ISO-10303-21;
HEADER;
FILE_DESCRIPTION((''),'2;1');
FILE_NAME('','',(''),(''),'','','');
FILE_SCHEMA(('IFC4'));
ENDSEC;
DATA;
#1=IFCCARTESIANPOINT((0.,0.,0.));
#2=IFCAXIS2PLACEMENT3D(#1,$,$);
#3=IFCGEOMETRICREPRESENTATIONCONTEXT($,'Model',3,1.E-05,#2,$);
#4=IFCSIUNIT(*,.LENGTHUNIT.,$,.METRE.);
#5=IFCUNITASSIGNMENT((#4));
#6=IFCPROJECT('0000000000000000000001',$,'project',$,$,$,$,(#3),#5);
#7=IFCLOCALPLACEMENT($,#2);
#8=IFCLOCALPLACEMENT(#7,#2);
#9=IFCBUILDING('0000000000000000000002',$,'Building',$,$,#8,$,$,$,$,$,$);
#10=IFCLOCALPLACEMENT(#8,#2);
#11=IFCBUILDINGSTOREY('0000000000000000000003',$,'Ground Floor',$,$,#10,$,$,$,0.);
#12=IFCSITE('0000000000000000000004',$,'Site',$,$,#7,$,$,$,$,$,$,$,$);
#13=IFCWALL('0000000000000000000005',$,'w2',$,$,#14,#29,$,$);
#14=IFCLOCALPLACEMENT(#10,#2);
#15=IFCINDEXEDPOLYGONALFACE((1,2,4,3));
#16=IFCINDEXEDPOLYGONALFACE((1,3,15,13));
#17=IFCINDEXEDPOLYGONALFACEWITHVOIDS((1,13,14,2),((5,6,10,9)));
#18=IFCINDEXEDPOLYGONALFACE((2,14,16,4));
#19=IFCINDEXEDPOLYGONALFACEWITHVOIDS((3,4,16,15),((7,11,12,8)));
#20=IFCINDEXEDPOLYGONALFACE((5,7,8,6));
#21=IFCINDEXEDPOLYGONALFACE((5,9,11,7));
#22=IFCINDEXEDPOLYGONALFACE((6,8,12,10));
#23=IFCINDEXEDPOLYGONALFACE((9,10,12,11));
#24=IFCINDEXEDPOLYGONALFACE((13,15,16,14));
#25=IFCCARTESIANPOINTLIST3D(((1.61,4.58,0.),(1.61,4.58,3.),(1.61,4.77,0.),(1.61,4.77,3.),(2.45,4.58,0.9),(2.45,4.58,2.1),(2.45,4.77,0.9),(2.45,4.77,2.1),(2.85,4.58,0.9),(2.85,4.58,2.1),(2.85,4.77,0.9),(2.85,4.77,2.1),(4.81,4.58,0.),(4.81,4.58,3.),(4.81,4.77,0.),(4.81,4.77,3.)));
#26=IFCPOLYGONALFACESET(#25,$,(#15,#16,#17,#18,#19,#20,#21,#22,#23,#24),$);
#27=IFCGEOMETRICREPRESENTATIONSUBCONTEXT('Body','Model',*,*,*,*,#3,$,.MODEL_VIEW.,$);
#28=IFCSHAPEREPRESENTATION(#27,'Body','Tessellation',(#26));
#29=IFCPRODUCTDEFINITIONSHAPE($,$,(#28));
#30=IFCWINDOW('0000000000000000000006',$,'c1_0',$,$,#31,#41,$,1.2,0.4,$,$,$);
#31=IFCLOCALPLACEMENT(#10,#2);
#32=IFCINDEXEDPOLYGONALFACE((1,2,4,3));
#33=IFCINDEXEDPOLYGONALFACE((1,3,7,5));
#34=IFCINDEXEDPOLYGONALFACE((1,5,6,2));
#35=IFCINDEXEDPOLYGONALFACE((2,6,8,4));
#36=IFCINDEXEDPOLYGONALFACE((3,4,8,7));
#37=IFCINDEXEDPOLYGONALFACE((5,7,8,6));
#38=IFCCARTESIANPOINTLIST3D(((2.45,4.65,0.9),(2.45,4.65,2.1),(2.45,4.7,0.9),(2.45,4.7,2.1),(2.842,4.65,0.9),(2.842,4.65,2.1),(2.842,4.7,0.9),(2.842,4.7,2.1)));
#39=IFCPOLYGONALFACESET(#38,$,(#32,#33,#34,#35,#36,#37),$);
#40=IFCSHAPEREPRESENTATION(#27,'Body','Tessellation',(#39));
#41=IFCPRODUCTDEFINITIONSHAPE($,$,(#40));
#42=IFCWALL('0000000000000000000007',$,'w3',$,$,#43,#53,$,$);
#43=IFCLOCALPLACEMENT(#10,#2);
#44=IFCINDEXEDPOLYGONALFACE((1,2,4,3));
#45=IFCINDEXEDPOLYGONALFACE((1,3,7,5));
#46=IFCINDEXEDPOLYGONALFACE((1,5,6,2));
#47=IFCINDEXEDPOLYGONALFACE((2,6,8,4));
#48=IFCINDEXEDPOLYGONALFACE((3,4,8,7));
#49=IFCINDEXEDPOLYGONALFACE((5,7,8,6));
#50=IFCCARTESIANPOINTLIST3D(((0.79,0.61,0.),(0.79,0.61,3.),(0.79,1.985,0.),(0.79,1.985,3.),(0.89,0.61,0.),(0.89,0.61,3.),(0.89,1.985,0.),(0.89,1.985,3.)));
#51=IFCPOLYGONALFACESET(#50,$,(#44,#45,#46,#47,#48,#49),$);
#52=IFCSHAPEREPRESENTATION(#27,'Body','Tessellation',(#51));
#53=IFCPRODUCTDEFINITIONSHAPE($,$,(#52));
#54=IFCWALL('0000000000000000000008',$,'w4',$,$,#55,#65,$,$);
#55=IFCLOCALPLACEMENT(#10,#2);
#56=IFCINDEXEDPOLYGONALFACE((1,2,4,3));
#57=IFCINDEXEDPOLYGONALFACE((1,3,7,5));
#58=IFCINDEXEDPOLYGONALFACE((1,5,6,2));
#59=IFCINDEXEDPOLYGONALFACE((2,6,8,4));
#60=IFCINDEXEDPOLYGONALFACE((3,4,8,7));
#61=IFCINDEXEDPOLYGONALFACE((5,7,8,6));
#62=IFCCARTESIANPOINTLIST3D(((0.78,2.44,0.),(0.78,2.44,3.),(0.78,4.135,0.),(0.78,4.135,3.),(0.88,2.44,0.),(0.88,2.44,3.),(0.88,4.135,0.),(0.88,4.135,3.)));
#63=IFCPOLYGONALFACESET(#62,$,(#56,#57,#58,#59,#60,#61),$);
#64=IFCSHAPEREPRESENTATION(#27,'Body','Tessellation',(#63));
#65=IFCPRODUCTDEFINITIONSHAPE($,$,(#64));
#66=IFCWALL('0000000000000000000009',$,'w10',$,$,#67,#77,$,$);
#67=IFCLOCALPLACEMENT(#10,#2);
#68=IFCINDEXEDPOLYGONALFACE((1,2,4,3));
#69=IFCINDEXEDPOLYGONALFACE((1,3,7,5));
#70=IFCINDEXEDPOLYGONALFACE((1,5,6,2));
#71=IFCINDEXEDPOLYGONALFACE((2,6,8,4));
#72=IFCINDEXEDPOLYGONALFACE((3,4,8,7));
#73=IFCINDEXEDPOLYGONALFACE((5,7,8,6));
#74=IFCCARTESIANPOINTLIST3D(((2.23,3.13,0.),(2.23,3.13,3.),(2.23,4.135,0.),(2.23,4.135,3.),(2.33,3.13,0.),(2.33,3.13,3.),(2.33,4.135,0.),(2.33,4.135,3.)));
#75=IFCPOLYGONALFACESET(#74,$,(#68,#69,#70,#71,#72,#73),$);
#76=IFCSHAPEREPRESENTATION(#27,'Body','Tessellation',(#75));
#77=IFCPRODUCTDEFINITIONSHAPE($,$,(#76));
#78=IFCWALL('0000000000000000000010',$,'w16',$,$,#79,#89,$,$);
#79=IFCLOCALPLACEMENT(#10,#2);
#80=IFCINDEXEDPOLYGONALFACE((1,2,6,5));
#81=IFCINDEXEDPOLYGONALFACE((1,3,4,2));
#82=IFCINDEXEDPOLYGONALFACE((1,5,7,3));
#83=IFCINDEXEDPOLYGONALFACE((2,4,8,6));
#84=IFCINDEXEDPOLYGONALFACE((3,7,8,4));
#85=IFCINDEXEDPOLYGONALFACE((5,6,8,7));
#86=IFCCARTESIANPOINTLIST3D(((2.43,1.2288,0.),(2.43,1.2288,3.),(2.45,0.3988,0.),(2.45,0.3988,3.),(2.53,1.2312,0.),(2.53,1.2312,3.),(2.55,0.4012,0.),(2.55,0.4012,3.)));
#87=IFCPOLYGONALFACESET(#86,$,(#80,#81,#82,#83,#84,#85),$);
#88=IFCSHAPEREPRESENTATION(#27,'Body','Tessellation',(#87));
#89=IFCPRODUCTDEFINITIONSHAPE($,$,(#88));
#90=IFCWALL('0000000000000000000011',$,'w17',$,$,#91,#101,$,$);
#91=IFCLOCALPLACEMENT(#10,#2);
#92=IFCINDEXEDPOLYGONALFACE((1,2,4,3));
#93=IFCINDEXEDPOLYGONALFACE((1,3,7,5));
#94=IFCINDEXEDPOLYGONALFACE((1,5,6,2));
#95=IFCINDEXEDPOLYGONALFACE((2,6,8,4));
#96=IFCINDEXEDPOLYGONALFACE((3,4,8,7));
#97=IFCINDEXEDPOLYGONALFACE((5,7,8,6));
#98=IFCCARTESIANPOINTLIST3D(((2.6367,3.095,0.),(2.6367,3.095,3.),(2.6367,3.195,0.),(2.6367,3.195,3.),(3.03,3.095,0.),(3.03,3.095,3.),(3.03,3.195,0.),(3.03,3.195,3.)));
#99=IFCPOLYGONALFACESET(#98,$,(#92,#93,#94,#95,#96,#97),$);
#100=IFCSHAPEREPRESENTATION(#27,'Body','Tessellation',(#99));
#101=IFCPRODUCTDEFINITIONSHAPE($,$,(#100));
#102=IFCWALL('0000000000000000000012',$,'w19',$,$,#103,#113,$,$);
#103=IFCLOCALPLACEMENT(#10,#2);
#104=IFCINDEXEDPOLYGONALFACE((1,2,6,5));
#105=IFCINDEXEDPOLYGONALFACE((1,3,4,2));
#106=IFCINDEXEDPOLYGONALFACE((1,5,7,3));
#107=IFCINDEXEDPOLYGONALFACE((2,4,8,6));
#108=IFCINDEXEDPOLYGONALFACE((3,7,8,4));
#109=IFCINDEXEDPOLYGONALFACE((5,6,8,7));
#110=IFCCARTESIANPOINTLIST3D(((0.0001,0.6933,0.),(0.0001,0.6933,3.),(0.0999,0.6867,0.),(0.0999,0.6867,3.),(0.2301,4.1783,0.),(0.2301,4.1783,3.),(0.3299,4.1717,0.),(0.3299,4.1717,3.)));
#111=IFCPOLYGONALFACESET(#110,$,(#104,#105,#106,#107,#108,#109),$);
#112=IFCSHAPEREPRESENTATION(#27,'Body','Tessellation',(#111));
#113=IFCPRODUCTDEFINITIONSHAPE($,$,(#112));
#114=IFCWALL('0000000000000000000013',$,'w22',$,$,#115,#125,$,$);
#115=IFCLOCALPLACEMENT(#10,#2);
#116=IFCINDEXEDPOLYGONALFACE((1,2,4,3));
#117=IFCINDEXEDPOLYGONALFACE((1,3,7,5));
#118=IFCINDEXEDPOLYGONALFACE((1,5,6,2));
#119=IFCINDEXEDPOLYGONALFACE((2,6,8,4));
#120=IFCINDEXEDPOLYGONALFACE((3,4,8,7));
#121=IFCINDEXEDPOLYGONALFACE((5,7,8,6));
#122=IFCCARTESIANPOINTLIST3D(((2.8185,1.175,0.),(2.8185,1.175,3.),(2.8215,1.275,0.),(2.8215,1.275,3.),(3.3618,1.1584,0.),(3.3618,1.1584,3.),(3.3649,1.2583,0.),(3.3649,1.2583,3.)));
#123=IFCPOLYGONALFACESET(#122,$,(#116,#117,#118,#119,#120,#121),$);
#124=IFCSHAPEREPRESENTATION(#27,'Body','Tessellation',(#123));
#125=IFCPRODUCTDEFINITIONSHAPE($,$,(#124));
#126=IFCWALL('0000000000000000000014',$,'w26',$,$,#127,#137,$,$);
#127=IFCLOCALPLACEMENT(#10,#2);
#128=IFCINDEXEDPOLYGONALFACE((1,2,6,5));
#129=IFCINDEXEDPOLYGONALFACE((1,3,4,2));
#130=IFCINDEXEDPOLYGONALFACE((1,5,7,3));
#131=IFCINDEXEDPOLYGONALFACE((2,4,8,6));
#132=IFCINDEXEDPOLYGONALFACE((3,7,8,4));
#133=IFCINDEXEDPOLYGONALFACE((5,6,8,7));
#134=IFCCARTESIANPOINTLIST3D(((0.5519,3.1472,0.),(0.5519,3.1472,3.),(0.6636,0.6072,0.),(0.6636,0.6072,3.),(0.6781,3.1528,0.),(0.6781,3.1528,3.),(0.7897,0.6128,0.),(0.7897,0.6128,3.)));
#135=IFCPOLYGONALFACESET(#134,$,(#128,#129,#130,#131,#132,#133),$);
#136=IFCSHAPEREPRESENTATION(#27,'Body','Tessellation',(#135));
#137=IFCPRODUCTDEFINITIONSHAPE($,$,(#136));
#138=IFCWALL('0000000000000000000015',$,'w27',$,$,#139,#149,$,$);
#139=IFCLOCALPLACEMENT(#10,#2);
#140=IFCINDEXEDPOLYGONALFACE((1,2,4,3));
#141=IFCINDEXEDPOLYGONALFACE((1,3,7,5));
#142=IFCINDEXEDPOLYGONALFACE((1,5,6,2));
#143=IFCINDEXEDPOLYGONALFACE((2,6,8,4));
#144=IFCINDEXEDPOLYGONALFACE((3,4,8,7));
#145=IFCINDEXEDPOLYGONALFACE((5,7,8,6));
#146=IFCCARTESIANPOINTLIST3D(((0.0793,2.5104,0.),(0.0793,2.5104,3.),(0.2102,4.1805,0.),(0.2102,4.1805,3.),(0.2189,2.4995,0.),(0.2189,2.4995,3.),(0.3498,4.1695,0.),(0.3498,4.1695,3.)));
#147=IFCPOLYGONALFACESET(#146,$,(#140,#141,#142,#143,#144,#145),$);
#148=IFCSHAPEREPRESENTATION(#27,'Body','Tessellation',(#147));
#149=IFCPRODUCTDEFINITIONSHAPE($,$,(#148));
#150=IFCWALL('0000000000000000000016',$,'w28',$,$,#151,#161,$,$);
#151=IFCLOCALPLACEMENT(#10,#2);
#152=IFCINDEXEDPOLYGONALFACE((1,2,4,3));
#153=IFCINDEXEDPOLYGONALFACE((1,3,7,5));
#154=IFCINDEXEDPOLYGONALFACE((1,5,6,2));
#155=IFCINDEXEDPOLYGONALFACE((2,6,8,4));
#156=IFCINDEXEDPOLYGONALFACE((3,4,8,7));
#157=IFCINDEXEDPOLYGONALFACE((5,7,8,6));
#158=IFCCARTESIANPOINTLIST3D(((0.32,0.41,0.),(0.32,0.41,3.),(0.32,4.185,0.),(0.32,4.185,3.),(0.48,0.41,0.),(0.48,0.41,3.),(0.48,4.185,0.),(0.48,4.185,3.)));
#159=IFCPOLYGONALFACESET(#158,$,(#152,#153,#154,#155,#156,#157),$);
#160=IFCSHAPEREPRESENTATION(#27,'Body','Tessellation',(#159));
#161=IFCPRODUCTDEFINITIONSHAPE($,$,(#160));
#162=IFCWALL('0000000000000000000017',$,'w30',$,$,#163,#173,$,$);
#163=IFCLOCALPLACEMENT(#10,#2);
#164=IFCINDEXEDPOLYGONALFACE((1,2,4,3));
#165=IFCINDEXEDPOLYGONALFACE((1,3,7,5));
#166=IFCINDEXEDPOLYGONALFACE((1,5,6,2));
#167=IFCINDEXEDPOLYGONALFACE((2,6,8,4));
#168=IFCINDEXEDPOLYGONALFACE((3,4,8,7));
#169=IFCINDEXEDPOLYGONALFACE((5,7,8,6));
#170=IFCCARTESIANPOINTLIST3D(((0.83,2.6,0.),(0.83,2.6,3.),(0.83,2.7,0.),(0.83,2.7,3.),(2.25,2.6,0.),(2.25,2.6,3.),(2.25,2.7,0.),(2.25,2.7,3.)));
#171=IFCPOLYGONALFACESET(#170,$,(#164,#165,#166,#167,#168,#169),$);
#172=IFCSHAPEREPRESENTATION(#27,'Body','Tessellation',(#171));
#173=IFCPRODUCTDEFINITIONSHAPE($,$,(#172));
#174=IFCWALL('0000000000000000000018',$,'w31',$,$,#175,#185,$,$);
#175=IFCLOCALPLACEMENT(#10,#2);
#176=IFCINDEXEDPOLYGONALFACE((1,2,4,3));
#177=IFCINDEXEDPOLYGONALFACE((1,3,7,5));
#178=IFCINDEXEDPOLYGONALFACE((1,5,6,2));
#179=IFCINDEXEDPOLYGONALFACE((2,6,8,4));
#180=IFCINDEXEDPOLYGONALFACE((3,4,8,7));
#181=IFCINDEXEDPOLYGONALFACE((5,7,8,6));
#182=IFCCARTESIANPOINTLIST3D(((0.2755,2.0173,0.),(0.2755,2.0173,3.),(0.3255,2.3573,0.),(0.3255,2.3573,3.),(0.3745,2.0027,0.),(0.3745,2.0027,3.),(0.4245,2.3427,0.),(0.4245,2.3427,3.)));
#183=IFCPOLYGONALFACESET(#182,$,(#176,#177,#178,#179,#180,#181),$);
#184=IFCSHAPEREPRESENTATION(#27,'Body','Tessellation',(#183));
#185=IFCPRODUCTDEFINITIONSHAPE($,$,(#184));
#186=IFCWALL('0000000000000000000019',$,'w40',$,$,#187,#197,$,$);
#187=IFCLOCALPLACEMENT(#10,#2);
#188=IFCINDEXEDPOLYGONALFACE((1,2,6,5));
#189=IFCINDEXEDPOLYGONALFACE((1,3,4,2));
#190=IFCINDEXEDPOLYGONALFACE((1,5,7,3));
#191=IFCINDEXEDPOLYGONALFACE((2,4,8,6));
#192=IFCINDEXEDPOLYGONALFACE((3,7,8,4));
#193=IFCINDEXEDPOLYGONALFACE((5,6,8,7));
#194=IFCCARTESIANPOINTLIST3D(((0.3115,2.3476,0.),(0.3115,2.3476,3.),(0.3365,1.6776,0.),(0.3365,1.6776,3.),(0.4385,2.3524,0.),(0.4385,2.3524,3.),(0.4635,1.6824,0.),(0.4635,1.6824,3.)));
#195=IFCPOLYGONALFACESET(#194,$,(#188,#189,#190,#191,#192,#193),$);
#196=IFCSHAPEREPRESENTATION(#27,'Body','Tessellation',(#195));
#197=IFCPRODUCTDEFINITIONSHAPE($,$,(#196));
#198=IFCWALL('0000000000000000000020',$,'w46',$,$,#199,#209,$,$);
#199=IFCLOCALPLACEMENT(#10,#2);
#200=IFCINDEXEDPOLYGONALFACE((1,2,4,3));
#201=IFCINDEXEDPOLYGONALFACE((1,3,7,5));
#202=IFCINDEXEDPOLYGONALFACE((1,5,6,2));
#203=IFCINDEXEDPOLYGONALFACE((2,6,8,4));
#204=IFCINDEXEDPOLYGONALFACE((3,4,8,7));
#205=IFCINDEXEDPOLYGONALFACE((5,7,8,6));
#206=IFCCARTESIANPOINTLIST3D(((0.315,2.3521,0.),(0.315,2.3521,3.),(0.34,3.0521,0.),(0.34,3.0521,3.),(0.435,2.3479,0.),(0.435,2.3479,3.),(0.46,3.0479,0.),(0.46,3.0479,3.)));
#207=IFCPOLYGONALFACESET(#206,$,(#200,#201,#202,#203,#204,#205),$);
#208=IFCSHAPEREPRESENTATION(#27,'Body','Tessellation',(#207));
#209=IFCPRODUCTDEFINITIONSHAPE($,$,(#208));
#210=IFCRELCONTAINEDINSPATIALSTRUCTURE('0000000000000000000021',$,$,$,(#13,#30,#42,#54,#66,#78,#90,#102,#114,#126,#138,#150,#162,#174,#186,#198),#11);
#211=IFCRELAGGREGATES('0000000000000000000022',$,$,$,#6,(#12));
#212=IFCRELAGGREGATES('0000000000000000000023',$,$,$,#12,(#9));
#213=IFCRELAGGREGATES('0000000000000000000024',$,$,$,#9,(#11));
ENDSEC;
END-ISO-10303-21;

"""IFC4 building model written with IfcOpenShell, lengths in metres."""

from ifc_helpers import new_model, si_unit, frame, origin, place, context, subcontext, project, spatial, polyline, outline, extrude, element, fill, save


model = new_model("IFC4")

# Units and contexts
model_context = context("Model", 3, precision=1e-05, world=origin())
body_context = subcontext(model_context, "Body", "Model", "MODEL_VIEW")
ifc_project = project(units=[si_unit("LENGTHUNIT", "METRE")], contexts=[model_context])

# Site, building, storey
site_placement = place(None, origin())
site = spatial("IfcSite", under=ifc_project, at=site_placement, Name="Site")
building_placement = place(site_placement, origin())
building = spatial("IfcBuilding", under=site, at=building_placement, Name="Building")
storey_placement = place(building_placement, origin())
storey = spatial("IfcBuildingStorey", under=building, at=storey_placement, Name="Ground Floor", Elevation=0.0)

# Wall, opening, window
wall_1_placement = place(storey_placement, frame((1.61, 4.675, 0.0), x_axis=(1.0, 0.0, 0.0)))
wall_1 = element("IfcWall", 1, at=wall_1_placement, inside=storey, Name="w2", context=body_context, shape_type="SweptSolid", body=[
    extrude(outline(polyline([(0.0, -0.095), (3.2, -0.095), (3.2, 0.095), (0.0, 0.095), (0.0, -0.095)])), origin(), (0.0, 0.0, 1.0), 3.0),
])
opening_1_placement = place(wall_1_placement, frame((0.84, 0.0, 0.0)))
opening_1 = element("IfcOpeningElement", 2, at=opening_1_placement, cuts=wall_1, context=body_context, shape_type="SweptSolid", body=[
    extrude(outline(polyline([(0.0, -0.0998), (0.4, -0.0998), (0.4, 0.0998), (0.0, 0.0998), (0.0, -0.0998)])), frame((0.0, 0.0, 0.9)), (0.0, 0.0, 1.0), 1.2),
])
window_placement = place(wall_1_placement, frame((0.84, 0.0, 0.0)))
window = element("IfcWindow", 3, at=window_placement, inside=storey, Name="c1_0", OverallHeight=1.2, OverallWidth=0.4, context=body_context, shape_type="SweptSolid", body=[
    extrude(outline(polyline([(0.0, -0.025), (0.392, -0.025), (0.392, 0.025), (0.0, 0.025), (0.0, -0.025)])), frame((0.0, 0.0, 0.9)), (0.0, 0.0, 1.0), 1.2),
])
fill(opening_1, window)

# Walls
wall_2_placement = place(storey_placement, frame((0.84, 0.61, 0.0), x_axis=(0.0, 1.0, 0.0)))
element("IfcWall", 4, at=wall_2_placement, inside=storey, Name="w3", context=body_context, shape_type="SweptSolid", body=[
    extrude(outline(polyline([(0.0, -0.05), (1.375, -0.05), (1.375, 0.05), (0.0, 0.05), (0.0, -0.05)])), origin(), (0.0, 0.0, 1.0), 3.0),
])
wall_3_placement = place(storey_placement, frame((0.83, 2.44, 0.0), x_axis=(0.0, 1.0, 0.0)))
element("IfcWall", 5, at=wall_3_placement, inside=storey, Name="w4", context=body_context, shape_type="SweptSolid", body=[
    extrude(outline(polyline([(0.0, -0.05), (1.695, -0.05), (1.695, 0.05), (0.0, 0.05), (0.0, -0.05)])), origin(), (0.0, 0.0, 1.0), 3.0),
])
wall_4_placement = place(storey_placement, frame((2.28, 3.13, 0.0), x_axis=(0.0, 1.0, 0.0)))
element("IfcWall", 6, at=wall_4_placement, inside=storey, Name="w10", context=body_context, shape_type="SweptSolid", body=[
    extrude(outline(polyline([(0.0, -0.05), (1.005, -0.05), (1.005, 0.05), (0.0, 0.05), (0.0, -0.05)])), origin(), (0.0, 0.0, 1.0), 3.0),
])
wall_5_placement = place(storey_placement, frame((2.5, 0.4, 0.0), x_axis=(-0.024089, 0.99971, 0.0)))
element("IfcWall", 7, at=wall_5_placement, inside=storey, Name="w16", context=body_context, shape_type="SweptSolid", body=[
    extrude(outline(polyline([(0.0, -0.05), (0.8302, -0.05), (0.8302, 0.05), (0.0, 0.05), (0.0, -0.05)])), origin(), (0.0, 0.0, 1.0), 3.0),
])
wall_6_placement = place(storey_placement, frame((2.6367, 3.145, 0.0), x_axis=(1.0, 0.0, 0.0)))
element("IfcWall", 8, at=wall_6_placement, inside=storey, Name="w17", context=body_context, shape_type="SweptSolid", body=[
    extrude(outline(polyline([(0.0, -0.05), (0.3933, -0.05), (0.3933, 0.05), (0.0, 0.05), (0.0, -0.05)])), origin(), (0.0, 0.0, 1.0), 3.0),
])
wall_7_placement = place(storey_placement, frame((0.05, 0.69, 0.0), x_axis=(0.065854, 0.997829, 0.0)))
element("IfcWall", 9, at=wall_7_placement, inside=storey, Name="w19", context=body_context, shape_type="SweptSolid", body=[
    extrude(outline(polyline([(0.0, -0.05), (3.4926, -0.05), (3.4926, 0.05), (0.0, 0.05), (0.0, -0.05)])), origin(), (0.0, 0.0, 1.0), 3.0),
])
wall_8_placement = place(storey_placement, frame((2.82, 1.225, 0.0), x_axis=(0.99953, -0.03066, 0.0)))
element("IfcWall", 10, at=wall_8_placement, inside=storey, Name="w22", context=body_context, shape_type="SweptSolid", body=[
    extrude(outline(polyline([(0.0, -0.05), (0.5436, -0.05), (0.5436, 0.05), (0.0, 0.05), (0.0, -0.05)])), origin(), (0.0, 0.0, 1.0), 3.0),
])
wall_9_placement = place(storey_placement, frame((0.7267, 0.61, 0.0), x_axis=(-0.04392, 0.999035, 0.0)))
element("IfcWall", 11, at=wall_9_placement, inside=storey, Name="w26", context=body_context, shape_type="SweptSolid", body=[
    extrude(outline(polyline([(0.0, -0.0631), (2.5425, -0.0631), (2.5425, 0.0631), (0.0, 0.0631), (0.0, -0.0631)])), origin(), (0.0, 0.0, 1.0), 3.0),
])
wall_10_placement = place(storey_placement, frame((0.1491, 2.505, 0.0), x_axis=(0.078146, 0.996942, 0.0)))
element("IfcWall", 12, at=wall_10_placement, inside=storey, Name="w27", context=body_context, shape_type="SweptSolid", body=[
    extrude(outline(polyline([(0.0, -0.07), (1.6752, -0.07), (1.6752, 0.07), (0.0, 0.07), (0.0, -0.07)])), origin(), (0.0, 0.0, 1.0), 3.0),
])
wall_11_placement = place(storey_placement, frame((0.4, 0.41, 0.0), x_axis=(0.0, 1.0, 0.0)))
element("IfcWall", 13, at=wall_11_placement, inside=storey, Name="w28", context=body_context, shape_type="SweptSolid", body=[
    extrude(outline(polyline([(0.0, -0.08), (3.775, -0.08), (3.775, 0.08), (0.0, 0.08), (0.0, -0.08)])), origin(), (0.0, 0.0, 1.0), 3.0),
])
wall_12_placement = place(storey_placement, frame((0.83, 2.65, 0.0), x_axis=(1.0, 0.0, 0.0)))
element("IfcWall", 14, at=wall_12_placement, inside=storey, Name="w30", context=body_context, shape_type="SweptSolid", body=[
    extrude(outline(polyline([(0.0, -0.05), (1.42, -0.05), (1.42, 0.05), (0.0, 0.05), (0.0, -0.05)])), origin(), (0.0, 0.0, 1.0), 3.0),
])
wall_13_placement = place(storey_placement, frame((0.325, 2.01, 0.0), x_axis=(0.145498, 0.989359, 0.0)))
element("IfcWall", 15, at=wall_13_placement, inside=storey, Name="w31", context=body_context, shape_type="SweptSolid", body=[
    extrude(outline(polyline([(0.0, -0.05), (0.3437, -0.05), (0.3437, 0.05), (0.0, 0.05), (0.0, -0.05)])), origin(), (0.0, 0.0, 1.0), 3.0),
])
wall_14_placement = place(storey_placement, frame((0.4, 1.68, 0.0), x_axis=(-0.037288, 0.999305, 0.0)))
element("IfcWall", 16, at=wall_14_placement, inside=storey, Name="w40", context=body_context, shape_type="SweptSolid", body=[
    extrude(outline(polyline([(0.0, -0.0635), (0.6705, -0.0635), (0.6705, 0.0635), (0.0, 0.0635), (0.0, -0.0635)])), origin(), (0.0, 0.0, 1.0), 3.0),
])
wall_15_placement = place(storey_placement, frame((0.375, 2.35, 0.0), x_axis=(0.035692, 0.999363, 0.0)))
element("IfcWall", 17, at=wall_15_placement, inside=storey, Name="w46", context=body_context, shape_type="SweptSolid", body=[
    extrude(outline(polyline([(0.0, -0.06), (0.7004, -0.06), (0.7004, 0.06), (0.0, 0.06), (0.0, -0.06)])), origin(), (0.0, 0.0, 1.0), 3.0),
])

save(model, "model.ifc")
